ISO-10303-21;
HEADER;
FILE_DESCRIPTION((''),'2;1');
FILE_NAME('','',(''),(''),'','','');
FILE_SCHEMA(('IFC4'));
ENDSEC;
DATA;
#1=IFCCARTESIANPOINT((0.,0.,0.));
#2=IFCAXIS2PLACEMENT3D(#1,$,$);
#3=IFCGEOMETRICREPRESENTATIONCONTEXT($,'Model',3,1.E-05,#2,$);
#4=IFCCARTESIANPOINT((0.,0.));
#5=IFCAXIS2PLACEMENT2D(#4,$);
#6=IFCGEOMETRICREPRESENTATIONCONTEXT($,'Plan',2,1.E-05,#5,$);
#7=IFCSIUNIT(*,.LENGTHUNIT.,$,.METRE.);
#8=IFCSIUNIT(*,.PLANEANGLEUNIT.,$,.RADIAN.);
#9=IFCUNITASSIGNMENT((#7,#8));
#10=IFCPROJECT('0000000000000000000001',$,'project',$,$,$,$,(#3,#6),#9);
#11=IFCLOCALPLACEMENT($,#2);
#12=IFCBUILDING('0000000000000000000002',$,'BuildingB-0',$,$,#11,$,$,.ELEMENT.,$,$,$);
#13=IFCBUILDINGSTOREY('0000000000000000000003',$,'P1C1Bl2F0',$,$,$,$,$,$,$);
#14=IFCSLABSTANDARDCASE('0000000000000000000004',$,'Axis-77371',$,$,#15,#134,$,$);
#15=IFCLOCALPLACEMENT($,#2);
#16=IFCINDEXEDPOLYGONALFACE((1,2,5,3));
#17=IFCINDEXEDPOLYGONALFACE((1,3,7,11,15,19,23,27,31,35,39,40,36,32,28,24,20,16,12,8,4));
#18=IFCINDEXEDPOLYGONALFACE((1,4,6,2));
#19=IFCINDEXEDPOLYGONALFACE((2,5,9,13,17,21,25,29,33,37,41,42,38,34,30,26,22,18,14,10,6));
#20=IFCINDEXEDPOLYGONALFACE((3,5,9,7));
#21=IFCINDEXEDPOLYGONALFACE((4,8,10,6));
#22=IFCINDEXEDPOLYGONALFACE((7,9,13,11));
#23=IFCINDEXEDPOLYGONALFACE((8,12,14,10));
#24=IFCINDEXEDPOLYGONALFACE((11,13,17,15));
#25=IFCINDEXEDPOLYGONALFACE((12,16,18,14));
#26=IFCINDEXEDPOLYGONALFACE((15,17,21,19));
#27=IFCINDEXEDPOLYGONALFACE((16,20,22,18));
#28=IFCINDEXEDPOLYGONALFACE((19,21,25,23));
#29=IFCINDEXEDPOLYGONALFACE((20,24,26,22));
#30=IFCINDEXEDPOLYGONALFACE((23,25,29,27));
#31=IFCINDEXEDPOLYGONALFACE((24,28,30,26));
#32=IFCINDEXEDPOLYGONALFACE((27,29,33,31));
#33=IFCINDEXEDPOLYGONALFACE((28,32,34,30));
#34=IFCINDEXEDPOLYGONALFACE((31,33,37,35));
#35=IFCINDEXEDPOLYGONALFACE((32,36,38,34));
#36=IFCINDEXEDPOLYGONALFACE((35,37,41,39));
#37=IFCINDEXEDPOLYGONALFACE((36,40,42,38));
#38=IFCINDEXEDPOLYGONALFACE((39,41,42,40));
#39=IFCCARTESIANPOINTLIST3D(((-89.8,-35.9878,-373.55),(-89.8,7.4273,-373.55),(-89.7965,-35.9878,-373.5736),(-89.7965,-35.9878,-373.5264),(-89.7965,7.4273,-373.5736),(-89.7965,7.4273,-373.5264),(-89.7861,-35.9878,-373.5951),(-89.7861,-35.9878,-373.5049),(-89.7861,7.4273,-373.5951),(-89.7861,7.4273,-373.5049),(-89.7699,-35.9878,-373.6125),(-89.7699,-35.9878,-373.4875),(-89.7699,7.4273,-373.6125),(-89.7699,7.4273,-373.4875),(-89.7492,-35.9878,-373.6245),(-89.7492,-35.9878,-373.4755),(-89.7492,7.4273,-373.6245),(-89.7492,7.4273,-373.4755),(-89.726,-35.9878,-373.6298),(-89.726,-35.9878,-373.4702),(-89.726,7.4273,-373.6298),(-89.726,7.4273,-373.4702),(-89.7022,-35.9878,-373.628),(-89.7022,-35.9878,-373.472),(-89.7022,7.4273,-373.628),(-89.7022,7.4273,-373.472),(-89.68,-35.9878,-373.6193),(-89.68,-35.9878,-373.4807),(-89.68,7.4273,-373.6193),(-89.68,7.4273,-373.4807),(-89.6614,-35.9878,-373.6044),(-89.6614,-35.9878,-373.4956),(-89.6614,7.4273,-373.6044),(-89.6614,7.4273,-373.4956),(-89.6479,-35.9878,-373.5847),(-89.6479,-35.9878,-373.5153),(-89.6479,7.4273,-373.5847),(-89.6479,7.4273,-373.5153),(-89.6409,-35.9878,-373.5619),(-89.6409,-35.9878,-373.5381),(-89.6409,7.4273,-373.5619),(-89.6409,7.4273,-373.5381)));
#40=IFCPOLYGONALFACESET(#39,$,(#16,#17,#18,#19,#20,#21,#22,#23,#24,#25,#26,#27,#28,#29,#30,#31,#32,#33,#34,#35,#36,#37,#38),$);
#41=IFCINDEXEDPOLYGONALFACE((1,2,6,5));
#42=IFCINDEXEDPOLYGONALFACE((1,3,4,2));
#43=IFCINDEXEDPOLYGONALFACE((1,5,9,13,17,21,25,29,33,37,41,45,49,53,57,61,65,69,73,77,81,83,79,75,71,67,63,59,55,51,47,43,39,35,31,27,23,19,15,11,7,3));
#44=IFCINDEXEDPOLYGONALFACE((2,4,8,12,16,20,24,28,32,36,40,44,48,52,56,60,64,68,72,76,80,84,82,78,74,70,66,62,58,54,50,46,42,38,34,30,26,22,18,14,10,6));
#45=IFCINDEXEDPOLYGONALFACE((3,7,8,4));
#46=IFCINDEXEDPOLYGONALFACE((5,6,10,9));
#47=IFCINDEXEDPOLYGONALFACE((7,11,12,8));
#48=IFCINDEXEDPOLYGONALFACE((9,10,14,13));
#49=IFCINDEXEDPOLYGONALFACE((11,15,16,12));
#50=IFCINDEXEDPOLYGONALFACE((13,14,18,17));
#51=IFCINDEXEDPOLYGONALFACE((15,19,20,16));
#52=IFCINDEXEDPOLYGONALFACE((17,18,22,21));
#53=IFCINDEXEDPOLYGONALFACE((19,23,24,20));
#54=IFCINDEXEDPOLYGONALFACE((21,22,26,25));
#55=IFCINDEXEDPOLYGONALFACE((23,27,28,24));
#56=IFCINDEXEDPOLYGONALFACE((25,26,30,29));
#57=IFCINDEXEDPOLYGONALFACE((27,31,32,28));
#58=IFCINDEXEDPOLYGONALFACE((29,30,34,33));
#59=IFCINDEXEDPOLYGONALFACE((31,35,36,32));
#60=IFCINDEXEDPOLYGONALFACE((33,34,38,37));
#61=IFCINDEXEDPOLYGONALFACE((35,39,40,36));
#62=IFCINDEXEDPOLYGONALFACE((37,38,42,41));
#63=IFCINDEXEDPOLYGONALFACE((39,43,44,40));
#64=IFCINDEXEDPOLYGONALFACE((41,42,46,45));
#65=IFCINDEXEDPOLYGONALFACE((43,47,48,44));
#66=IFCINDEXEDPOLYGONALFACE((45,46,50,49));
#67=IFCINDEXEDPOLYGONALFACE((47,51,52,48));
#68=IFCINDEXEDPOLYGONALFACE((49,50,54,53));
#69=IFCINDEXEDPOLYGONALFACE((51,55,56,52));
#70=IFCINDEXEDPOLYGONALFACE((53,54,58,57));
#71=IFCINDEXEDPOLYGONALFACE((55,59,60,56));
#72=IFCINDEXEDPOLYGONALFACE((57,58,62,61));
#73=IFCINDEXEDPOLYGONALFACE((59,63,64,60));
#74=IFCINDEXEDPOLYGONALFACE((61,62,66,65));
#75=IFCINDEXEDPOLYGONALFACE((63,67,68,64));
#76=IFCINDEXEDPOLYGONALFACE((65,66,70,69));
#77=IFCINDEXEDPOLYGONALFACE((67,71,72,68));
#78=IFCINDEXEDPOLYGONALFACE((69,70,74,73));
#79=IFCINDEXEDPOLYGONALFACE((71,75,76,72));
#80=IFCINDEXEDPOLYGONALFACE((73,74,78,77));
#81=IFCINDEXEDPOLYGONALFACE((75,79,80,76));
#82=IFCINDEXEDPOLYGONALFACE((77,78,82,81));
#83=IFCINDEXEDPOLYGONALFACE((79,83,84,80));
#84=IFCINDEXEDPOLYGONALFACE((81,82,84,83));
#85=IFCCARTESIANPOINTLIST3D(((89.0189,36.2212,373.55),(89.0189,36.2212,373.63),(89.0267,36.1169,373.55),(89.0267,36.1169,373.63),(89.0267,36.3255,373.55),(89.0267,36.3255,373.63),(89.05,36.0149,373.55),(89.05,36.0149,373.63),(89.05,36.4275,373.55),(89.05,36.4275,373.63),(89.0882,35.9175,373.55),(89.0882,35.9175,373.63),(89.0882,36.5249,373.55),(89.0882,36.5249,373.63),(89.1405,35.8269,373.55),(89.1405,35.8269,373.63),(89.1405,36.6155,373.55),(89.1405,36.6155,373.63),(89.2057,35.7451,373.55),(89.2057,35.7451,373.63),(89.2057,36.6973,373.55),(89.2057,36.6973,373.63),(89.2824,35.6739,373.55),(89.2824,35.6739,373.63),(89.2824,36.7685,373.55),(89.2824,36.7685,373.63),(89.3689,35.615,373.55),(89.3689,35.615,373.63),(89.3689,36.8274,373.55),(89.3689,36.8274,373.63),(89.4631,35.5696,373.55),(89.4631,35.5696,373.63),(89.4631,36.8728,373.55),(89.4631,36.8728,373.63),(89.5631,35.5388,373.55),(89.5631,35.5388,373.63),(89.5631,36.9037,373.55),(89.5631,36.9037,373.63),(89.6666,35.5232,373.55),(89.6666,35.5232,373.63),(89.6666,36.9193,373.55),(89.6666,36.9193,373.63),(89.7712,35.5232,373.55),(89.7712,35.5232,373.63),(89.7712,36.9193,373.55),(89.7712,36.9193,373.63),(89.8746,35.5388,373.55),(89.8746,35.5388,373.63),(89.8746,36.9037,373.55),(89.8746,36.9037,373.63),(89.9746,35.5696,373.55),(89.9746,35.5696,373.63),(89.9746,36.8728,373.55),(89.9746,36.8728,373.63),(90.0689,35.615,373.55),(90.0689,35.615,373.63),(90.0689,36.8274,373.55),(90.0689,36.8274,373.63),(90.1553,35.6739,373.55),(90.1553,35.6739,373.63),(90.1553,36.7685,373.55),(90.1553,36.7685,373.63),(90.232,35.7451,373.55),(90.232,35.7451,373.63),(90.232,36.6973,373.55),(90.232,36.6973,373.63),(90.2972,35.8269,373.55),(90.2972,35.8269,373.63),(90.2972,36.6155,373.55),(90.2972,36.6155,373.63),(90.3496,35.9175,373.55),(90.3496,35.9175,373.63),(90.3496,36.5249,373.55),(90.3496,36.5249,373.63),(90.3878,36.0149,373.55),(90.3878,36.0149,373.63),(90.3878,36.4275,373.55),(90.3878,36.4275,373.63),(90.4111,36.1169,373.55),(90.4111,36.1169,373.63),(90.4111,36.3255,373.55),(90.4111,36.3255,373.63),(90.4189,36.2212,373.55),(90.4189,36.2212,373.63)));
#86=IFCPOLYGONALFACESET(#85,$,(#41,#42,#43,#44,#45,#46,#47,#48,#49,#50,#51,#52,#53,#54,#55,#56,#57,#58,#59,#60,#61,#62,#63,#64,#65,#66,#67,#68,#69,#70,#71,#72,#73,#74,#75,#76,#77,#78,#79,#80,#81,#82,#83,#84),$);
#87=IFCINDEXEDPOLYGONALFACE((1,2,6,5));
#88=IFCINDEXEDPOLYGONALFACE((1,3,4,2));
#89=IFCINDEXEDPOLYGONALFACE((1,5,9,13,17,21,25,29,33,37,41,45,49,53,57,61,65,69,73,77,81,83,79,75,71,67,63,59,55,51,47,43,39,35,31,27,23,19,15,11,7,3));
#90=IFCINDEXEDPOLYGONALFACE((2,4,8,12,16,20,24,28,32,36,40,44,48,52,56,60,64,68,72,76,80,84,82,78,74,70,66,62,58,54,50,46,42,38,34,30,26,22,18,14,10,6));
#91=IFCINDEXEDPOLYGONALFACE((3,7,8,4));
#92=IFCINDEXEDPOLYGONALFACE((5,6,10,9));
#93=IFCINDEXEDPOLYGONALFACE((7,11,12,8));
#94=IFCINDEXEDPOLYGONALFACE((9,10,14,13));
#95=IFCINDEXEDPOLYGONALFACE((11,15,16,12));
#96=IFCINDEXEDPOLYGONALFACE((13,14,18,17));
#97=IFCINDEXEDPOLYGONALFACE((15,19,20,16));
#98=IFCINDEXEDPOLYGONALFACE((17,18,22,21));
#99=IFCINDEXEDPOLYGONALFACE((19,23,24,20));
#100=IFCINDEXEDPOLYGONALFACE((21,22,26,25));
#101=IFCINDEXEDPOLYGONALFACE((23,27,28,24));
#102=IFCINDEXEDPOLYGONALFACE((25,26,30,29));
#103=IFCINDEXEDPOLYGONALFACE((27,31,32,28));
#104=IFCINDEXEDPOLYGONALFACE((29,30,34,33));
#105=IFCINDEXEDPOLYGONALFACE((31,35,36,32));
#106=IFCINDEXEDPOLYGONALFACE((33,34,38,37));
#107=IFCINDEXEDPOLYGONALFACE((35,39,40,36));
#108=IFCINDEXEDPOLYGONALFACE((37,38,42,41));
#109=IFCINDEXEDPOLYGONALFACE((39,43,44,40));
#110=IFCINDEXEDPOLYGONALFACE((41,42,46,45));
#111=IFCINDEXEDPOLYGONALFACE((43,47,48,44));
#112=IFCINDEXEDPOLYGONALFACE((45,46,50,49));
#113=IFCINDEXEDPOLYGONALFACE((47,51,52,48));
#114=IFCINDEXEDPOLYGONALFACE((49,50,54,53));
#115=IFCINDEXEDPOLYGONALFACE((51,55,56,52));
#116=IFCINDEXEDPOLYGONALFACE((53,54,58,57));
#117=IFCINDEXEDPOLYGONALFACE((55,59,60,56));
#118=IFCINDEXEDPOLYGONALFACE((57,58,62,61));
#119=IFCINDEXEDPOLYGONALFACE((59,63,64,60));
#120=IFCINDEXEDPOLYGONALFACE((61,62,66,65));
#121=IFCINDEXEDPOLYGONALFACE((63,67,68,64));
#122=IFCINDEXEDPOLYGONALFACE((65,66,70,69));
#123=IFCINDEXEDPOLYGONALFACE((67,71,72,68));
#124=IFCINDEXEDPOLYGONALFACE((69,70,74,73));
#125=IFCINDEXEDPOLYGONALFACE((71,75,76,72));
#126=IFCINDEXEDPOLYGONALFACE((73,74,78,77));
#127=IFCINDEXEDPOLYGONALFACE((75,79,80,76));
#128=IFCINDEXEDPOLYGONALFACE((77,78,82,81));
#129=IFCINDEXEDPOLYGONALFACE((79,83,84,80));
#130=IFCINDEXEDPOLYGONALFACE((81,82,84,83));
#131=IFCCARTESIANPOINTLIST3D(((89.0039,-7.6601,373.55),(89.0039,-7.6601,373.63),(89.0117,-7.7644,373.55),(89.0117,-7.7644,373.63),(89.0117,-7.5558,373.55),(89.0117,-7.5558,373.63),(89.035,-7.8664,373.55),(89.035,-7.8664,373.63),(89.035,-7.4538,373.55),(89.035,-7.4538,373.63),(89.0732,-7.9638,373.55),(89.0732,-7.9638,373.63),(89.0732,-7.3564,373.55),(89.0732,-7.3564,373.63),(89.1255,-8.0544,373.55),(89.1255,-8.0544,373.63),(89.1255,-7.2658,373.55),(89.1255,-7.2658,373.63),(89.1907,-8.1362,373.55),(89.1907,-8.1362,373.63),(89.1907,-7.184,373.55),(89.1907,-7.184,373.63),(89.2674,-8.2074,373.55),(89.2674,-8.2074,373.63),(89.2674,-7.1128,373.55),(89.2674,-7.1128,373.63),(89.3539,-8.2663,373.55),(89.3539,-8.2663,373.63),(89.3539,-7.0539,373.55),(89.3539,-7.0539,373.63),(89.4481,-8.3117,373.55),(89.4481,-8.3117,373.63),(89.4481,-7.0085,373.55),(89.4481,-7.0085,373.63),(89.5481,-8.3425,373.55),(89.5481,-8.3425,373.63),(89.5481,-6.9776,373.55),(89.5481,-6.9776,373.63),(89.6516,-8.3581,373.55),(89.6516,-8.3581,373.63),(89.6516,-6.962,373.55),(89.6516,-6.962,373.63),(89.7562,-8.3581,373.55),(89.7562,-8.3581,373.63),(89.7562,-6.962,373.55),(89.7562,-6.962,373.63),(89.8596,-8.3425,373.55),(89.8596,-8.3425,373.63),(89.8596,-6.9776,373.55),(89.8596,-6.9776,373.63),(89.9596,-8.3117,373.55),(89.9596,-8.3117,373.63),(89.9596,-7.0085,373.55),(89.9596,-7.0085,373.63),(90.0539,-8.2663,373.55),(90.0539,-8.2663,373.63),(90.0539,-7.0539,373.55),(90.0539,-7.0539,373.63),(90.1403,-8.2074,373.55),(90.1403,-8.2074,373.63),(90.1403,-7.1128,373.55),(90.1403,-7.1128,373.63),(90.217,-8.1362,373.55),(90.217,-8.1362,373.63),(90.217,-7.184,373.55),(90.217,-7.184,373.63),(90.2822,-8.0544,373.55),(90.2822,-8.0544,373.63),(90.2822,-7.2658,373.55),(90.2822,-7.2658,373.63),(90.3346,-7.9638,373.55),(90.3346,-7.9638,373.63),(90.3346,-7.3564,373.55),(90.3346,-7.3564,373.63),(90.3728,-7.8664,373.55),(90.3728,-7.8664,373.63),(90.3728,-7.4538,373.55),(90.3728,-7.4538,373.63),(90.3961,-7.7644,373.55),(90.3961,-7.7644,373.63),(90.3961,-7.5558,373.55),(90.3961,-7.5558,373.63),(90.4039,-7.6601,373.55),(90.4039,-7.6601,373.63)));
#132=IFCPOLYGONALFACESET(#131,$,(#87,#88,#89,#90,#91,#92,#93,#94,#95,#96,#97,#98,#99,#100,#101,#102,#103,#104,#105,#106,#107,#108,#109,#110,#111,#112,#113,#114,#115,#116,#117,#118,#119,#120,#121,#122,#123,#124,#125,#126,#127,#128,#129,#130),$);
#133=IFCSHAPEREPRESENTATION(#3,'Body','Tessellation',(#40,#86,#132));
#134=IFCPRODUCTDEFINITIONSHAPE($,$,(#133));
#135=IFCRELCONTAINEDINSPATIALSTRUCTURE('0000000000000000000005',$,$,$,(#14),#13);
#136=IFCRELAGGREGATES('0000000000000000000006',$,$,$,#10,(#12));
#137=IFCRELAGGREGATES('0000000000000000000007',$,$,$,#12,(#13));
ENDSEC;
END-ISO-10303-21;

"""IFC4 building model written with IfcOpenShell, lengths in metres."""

from ifc_helpers import new_model, entity, si_unit, frame, origin, origin_2d, place, context, project, spatial, circle, extrude, element, save


model = new_model("IFC4")

# Units and contexts
model_context = context("Model", 3, precision=1e-05, world=origin())
plan_context = context("Plan", 2, precision=1e-05, world=origin_2d())
ifc_project = project(units=[si_unit("LENGTHUNIT", "METRE"), si_unit("PLANEANGLEUNIT", "RADIAN")], contexts=[model_context, plan_context])

# Building, storey
building_placement = place(None, origin())
building = spatial("IfcBuilding", under=ifc_project, at=building_placement, Name="BuildingB-0", CompositionType="ELEMENT")
storey = spatial("IfcBuildingStorey", under=building, Name="P1C1Bl2F0")

# Slab
element("IfcSlabStandardCase", 1, inside=storey, Name="Axis-77371", context=model_context, shape_type="AdvancedSweptSolid", body=[
    entity("IfcSurfaceCurveSweptAreaSolid", entity("IfcCircleProfileDef", "AREA", None, None, 0.08), None, entity("IfcPolyline", [entity("IfcCartesianPoint", [89.72, 35.9878, 373.55]), entity("IfcCartesianPoint", [89.72, -7.4273, 373.55])]), None, None, entity("IfcPlane", entity("IfcAxis2Placement3D", entity("IfcCartesianPoint", [89.72, 35.9878, 373.55]), entity("IfcDirection", [0.0, 0.0, 1.0]), entity("IfcDirection", [1.0, 0.0, 0.0])))),
    extrude(circle(Radius=0.7), frame((89.7189, 36.2212, 373.55)), (0.0, 0.0, 1.0), 0.08),
    extrude(circle(Radius=0.7), frame((89.7039, -7.6601, 373.55)), (0.0, 0.0, 1.0), 0.08),
])

save(model, "model.ifc")
